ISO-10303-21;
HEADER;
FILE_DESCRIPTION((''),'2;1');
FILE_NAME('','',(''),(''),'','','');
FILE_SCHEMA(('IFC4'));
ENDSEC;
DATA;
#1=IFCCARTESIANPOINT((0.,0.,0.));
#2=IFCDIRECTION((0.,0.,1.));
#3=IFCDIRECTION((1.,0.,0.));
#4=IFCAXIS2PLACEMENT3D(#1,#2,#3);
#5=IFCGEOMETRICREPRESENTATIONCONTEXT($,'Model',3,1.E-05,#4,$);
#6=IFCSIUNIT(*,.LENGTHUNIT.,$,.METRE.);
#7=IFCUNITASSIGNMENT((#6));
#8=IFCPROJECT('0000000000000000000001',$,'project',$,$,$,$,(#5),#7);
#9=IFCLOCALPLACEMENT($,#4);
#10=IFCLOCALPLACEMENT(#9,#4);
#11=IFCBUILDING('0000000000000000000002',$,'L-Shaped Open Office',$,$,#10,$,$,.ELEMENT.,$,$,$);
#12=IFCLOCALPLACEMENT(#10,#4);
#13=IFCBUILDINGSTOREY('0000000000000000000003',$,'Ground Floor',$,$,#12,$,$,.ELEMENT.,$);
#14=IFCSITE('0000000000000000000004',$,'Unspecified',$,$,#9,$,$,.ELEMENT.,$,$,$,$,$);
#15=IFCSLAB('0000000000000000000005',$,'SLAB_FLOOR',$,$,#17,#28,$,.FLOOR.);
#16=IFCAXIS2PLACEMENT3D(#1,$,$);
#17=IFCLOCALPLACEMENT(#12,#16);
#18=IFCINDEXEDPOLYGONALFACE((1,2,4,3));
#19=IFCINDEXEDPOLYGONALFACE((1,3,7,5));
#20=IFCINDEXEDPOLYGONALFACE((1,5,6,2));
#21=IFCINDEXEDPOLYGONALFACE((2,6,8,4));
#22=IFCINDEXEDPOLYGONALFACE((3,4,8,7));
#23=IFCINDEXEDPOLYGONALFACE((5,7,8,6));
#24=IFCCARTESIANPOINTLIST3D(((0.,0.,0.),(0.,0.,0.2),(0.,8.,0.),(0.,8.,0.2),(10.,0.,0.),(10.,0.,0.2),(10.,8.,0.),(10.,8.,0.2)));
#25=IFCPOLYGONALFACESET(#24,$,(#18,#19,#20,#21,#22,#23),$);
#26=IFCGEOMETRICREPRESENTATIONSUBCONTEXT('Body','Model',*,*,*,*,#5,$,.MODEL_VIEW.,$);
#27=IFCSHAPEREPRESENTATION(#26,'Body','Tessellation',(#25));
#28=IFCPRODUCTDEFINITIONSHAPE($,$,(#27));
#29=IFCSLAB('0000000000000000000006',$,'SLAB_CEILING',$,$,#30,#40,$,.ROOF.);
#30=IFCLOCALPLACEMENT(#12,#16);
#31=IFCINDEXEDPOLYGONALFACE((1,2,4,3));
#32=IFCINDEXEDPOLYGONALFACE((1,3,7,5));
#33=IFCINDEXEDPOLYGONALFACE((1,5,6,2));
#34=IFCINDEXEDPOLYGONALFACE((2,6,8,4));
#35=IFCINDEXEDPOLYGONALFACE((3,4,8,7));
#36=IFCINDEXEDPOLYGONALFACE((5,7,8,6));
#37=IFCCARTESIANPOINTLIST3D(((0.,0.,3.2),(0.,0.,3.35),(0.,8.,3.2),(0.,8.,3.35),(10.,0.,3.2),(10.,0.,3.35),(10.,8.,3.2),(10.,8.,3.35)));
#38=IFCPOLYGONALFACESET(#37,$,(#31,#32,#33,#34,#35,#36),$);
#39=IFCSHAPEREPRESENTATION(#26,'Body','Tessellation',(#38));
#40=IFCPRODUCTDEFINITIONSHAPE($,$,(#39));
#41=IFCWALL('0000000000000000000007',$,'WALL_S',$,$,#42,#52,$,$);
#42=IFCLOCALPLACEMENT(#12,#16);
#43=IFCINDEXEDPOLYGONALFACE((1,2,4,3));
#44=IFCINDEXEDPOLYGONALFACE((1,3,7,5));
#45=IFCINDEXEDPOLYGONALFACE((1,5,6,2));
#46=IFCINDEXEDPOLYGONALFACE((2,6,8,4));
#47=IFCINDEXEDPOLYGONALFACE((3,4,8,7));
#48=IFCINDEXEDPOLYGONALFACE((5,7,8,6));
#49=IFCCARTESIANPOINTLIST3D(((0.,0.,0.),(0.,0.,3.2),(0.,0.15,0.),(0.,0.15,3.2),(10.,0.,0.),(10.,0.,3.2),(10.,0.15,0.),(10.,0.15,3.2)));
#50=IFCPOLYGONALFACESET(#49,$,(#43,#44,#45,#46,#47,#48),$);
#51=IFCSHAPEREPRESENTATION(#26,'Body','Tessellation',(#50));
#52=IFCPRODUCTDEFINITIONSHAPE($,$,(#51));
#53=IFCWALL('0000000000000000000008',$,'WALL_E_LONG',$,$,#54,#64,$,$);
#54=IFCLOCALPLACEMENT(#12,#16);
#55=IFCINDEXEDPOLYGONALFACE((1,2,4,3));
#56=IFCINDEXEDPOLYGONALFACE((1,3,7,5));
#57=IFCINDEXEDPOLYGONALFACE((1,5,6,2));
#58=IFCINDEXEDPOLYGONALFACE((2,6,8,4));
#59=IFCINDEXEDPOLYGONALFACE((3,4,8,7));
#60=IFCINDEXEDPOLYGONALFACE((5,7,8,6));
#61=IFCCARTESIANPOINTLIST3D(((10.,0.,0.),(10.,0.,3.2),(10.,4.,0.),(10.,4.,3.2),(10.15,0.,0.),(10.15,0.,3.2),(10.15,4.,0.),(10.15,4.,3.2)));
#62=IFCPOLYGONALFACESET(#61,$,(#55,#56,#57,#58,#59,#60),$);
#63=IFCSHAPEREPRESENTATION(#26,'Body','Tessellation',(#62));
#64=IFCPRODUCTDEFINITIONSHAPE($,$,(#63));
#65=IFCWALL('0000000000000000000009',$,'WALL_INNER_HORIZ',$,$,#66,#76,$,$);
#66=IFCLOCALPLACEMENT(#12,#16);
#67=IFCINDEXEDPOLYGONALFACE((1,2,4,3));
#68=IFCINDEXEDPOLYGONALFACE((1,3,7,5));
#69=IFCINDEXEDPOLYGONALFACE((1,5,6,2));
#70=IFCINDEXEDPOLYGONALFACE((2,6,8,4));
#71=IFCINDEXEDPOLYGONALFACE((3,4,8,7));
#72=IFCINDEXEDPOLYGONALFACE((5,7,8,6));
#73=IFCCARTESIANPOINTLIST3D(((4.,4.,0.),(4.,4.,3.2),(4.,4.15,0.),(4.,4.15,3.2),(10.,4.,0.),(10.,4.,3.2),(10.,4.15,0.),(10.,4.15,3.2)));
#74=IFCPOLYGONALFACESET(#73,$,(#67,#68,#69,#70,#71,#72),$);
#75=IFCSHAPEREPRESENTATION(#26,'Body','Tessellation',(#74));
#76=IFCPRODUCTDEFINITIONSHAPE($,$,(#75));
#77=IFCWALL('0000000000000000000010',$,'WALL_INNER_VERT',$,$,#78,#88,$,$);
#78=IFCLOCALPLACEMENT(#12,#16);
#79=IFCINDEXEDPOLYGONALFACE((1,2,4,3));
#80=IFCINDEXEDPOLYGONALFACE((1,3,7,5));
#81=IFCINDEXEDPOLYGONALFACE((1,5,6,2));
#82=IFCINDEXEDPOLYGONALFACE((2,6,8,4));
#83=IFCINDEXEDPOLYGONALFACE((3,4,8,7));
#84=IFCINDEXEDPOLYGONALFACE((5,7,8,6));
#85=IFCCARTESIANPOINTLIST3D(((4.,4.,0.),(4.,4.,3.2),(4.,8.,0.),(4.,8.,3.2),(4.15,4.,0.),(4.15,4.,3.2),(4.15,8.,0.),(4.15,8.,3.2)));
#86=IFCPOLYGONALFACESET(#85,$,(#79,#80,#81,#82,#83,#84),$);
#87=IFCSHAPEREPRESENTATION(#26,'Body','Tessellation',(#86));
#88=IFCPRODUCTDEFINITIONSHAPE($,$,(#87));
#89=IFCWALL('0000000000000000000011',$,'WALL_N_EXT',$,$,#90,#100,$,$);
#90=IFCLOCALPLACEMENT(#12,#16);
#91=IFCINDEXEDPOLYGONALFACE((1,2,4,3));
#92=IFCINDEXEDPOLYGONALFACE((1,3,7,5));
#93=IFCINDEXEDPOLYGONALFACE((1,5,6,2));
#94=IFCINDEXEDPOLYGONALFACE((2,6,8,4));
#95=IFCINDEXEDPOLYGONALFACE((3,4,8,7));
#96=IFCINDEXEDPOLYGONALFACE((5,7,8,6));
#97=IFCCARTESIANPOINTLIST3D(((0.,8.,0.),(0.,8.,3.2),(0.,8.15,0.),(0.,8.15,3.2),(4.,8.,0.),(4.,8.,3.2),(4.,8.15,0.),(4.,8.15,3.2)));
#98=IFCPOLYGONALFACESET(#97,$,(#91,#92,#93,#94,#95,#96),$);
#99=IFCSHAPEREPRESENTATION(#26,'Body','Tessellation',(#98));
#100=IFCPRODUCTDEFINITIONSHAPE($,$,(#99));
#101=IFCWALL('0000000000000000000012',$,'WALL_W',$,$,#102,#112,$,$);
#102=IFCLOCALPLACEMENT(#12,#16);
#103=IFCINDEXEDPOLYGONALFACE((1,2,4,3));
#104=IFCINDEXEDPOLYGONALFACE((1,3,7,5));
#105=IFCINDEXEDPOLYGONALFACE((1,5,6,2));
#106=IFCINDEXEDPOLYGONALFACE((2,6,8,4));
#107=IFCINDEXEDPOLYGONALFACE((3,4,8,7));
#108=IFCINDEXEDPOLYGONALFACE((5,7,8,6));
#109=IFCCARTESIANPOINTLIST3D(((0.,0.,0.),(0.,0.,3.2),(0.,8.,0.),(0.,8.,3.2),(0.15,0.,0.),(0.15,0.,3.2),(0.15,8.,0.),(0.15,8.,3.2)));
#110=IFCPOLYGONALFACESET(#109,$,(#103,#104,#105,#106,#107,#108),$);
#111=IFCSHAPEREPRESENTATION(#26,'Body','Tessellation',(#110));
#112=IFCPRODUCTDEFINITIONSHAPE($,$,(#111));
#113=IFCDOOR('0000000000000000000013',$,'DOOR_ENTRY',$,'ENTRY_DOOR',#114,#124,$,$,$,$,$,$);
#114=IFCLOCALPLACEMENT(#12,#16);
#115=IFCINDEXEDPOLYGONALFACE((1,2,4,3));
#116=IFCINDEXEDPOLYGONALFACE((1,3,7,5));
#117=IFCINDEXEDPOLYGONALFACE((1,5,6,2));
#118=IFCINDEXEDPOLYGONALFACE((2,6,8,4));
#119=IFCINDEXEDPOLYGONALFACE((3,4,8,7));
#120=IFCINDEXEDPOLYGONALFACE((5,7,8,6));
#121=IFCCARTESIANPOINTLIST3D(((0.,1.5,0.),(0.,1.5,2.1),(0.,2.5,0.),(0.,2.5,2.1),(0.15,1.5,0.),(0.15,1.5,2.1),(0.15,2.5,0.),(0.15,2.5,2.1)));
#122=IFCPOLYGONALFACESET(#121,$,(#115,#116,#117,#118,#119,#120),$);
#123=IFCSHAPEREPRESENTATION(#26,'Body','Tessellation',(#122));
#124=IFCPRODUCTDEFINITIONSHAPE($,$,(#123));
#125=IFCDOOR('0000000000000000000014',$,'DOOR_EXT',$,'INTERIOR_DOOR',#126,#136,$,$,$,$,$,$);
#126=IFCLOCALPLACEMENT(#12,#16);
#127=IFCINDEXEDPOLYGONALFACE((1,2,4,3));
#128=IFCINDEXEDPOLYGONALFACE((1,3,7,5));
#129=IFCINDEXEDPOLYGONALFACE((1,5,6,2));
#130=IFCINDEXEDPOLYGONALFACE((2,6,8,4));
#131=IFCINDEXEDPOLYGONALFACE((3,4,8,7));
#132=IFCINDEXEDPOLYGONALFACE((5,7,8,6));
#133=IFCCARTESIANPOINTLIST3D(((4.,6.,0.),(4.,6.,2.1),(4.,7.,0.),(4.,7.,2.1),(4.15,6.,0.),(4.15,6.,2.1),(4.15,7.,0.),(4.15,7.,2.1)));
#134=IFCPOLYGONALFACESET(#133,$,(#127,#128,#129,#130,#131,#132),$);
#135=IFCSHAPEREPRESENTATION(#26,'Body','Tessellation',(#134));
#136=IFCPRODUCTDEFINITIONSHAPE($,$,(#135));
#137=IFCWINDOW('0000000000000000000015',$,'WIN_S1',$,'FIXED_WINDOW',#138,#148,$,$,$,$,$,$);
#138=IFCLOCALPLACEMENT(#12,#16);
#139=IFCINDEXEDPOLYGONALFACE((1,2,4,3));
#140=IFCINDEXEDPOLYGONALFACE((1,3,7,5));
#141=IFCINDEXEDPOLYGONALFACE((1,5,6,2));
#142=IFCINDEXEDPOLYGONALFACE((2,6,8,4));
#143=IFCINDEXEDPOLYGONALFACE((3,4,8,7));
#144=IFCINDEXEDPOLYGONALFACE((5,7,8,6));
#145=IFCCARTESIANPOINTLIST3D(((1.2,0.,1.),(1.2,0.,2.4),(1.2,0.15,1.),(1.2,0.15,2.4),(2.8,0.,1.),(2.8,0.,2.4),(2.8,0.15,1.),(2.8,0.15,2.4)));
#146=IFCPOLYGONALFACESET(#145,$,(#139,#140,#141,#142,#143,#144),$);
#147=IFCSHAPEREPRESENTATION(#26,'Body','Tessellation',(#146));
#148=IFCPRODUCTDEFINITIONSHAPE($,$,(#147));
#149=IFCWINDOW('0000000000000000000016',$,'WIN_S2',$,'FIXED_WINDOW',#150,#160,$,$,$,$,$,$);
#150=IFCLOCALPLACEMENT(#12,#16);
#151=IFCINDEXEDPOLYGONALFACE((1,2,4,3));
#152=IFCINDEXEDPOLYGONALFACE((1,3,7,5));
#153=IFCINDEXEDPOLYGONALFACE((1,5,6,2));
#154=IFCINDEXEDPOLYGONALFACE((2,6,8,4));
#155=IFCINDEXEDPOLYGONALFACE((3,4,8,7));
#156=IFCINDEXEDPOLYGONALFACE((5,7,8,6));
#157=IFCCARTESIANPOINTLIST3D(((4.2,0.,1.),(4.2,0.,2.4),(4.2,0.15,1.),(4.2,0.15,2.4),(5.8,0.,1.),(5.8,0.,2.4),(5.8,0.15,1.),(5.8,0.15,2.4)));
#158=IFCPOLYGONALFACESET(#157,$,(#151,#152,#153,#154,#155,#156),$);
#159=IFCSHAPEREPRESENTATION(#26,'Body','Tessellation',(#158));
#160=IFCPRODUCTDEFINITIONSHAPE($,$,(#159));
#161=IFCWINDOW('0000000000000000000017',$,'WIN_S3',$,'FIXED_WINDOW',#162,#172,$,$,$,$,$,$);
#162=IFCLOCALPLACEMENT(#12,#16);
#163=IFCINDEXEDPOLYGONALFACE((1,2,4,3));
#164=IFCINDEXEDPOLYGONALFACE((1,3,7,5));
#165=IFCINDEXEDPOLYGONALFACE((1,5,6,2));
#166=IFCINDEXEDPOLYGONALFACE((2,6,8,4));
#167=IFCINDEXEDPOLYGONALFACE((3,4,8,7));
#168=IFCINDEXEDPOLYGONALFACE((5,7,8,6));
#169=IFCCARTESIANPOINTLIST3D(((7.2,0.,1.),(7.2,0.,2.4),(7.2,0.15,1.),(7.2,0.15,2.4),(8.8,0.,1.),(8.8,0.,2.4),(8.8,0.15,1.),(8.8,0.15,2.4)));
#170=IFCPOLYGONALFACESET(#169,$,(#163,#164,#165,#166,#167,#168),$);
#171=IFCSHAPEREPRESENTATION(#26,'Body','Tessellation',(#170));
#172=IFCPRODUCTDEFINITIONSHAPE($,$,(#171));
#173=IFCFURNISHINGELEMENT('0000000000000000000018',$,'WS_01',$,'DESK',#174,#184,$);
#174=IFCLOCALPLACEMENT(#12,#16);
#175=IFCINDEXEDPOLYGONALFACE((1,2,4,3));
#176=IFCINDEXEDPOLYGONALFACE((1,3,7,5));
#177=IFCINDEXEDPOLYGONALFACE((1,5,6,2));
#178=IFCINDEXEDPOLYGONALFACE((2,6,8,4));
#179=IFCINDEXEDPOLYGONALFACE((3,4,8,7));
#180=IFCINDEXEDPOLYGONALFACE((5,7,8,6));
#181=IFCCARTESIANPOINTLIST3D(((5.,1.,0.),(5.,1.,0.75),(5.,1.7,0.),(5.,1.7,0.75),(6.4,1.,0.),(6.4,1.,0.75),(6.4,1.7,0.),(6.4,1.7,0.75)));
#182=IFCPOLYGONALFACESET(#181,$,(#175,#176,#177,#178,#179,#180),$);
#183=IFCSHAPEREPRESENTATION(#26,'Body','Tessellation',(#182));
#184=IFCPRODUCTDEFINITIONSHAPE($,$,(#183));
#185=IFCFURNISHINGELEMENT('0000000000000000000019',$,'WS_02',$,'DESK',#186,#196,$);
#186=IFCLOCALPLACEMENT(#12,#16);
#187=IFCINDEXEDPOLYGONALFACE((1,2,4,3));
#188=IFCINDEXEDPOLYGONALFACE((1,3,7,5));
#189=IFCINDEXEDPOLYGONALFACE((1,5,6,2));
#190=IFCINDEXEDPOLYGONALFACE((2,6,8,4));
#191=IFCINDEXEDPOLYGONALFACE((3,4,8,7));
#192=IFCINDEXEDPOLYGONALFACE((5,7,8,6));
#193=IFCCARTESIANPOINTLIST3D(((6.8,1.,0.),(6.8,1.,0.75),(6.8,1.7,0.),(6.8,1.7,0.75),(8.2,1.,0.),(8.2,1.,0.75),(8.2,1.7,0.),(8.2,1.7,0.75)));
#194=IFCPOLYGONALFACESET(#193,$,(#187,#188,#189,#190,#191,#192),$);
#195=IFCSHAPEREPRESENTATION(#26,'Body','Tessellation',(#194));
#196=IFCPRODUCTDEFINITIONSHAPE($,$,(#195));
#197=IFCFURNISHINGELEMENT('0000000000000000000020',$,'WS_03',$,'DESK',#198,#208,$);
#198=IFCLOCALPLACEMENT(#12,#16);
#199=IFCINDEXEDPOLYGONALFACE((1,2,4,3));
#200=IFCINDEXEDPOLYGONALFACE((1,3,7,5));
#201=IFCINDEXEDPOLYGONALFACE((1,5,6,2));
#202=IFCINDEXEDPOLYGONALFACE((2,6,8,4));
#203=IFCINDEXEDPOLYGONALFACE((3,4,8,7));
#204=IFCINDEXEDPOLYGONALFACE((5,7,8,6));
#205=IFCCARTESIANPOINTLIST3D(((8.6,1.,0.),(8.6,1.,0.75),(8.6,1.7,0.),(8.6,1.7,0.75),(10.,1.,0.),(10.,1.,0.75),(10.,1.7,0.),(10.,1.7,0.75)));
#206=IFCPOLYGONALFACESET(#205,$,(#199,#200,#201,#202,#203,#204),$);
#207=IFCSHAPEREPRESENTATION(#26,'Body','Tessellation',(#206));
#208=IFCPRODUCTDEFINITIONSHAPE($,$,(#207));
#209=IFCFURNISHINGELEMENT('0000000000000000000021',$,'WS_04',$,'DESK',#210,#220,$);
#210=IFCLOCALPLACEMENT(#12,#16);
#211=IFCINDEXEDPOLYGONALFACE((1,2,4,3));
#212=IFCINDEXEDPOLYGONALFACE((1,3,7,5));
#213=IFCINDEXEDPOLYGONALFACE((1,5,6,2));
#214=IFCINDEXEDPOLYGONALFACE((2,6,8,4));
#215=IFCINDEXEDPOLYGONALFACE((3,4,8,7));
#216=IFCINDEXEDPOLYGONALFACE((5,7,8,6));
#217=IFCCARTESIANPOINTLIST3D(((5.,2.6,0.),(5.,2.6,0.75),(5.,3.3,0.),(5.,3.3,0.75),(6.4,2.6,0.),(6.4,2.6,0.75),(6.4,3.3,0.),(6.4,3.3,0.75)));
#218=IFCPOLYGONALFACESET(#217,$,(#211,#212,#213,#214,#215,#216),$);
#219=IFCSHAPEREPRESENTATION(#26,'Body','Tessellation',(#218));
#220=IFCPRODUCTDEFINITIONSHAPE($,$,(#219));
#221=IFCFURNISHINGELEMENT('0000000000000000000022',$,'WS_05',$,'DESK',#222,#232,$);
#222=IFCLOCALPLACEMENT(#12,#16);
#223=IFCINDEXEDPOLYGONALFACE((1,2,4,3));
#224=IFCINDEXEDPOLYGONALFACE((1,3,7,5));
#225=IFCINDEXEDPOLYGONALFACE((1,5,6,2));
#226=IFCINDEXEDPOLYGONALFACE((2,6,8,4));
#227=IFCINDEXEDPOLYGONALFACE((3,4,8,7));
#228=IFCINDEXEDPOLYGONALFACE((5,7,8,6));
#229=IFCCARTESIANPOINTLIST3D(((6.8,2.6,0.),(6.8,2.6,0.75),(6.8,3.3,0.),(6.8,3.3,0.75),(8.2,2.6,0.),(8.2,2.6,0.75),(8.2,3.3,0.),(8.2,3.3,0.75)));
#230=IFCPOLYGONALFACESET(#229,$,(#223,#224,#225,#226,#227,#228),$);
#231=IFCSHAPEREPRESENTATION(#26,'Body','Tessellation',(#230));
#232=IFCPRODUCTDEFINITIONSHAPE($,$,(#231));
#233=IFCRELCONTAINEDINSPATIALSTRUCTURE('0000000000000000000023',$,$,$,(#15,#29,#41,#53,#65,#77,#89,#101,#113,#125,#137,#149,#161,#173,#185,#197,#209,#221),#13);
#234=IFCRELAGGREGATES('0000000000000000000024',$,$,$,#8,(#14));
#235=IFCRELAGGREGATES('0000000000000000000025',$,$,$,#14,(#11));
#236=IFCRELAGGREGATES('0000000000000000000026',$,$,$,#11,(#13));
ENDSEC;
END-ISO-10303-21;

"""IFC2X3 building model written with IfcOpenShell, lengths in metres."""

from ifc_helpers import new_model, si_unit, frame, frame_2d, origin, origin_with_axes, place, context, subcontext, project, spatial, rectangle, extrude, element, save


model = new_model("IFC2X3")

# Units and contexts
model_context = context("Model", 3, precision=1e-05, world=origin_with_axes())
body_context = subcontext(model_context, "Body", "Model", "MODEL_VIEW")
ifc_project = project(units=[si_unit("LENGTHUNIT", "METRE")], contexts=[model_context])

# Site, building, storey
site_placement = place(None, origin_with_axes())
site = spatial("IfcSite", under=ifc_project, at=site_placement, Name="Unspecified", CompositionType="ELEMENT")
building_placement = place(site_placement, origin_with_axes())
building = spatial("IfcBuilding", under=site, at=building_placement, Name="L-Shaped Open Office", CompositionType="ELEMENT")
storey_placement = place(building_placement, origin_with_axes())
storey = spatial("IfcBuildingStorey", under=building, at=storey_placement, Name="Ground Floor", CompositionType="ELEMENT")

# Slabs
slab_1_placement = place(storey_placement, origin_with_axes())
element("IfcSlab", 1, at=slab_1_placement, inside=storey, Name="SLAB_FLOOR", PredefinedType="FLOOR", context=body_context, shape_type="SweptSolid", body=[
    extrude(rectangle(XDim=10.0, YDim=8.0, at=frame_2d((5.0, 4.0))), origin(), (0.0, 0.0, 1.0), 0.2),
])
slab_2_placement = place(storey_placement, frame((0.0, 0.0, 3.2), z_axis=(0.0, 0.0, 1.0), x_axis=(1.0, 0.0, 0.0)))
element("IfcSlab", 2, at=slab_2_placement, inside=storey, Name="SLAB_CEILING", PredefinedType="ROOF", context=body_context, shape_type="SweptSolid", body=[
    extrude(rectangle(XDim=10.0, YDim=8.0, at=frame_2d((5.0, 4.0))), origin(), (0.0, 0.0, 1.0), 0.15),
])

# Walls
wall_1_placement = place(storey_placement, origin_with_axes())
element("IfcWall", 3, at=wall_1_placement, inside=storey, Name="WALL_S", context=body_context, shape_type="SweptSolid", body=[
    extrude(rectangle(XDim=10.0, YDim=0.15, at=frame_2d((5.0, 0.075))), origin(), (0.0, 0.0, 1.0), 3.2),
])
wall_2_placement = place(storey_placement, frame((10.0, 0.0, 0.0), z_axis=(0.0, 0.0, 1.0), x_axis=(1.0, 0.0, 0.0)))
element("IfcWall", 4, at=wall_2_placement, inside=storey, Name="WALL_E_LONG", context=body_context, shape_type="SweptSolid", body=[
    extrude(rectangle(XDim=0.15, YDim=4.0, at=frame_2d((0.075, 2.0))), origin(), (0.0, 0.0, 1.0), 3.2),
])
wall_3_placement = place(storey_placement, frame((4.0, 4.0, 0.0), z_axis=(0.0, 0.0, 1.0), x_axis=(1.0, 0.0, 0.0)))
element("IfcWall", 5, at=wall_3_placement, inside=storey, Name="WALL_INNER_HORIZ", context=body_context, shape_type="SweptSolid", body=[
    extrude(rectangle(XDim=6.0, YDim=0.15, at=frame_2d((3.0, 0.075))), origin(), (0.0, 0.0, 1.0), 3.2),
])
wall_4_placement = place(storey_placement, frame((4.0, 4.0, 0.0), z_axis=(0.0, 0.0, 1.0), x_axis=(1.0, 0.0, 0.0)))
element("IfcWall", 6, at=wall_4_placement, inside=storey, Name="WALL_INNER_VERT", context=body_context, shape_type="SweptSolid", body=[
    extrude(rectangle(XDim=0.15, YDim=4.0, at=frame_2d((0.075, 2.0))), origin(), (0.0, 0.0, 1.0), 3.2),
])
wall_5_placement = place(storey_placement, frame((0.0, 8.0, 0.0), z_axis=(0.0, 0.0, 1.0), x_axis=(1.0, 0.0, 0.0)))
element("IfcWall", 7, at=wall_5_placement, inside=storey, Name="WALL_N_EXT", context=body_context, shape_type="SweptSolid", body=[
    extrude(rectangle(XDim=4.0, YDim=0.15, at=frame_2d((2.0, 0.075))), origin(), (0.0, 0.0, 1.0), 3.2),
])
wall_6_placement = place(storey_placement, origin_with_axes())
element("IfcWall", 8, at=wall_6_placement, inside=storey, Name="WALL_W", context=body_context, shape_type="SweptSolid", body=[
    extrude(rectangle(XDim=0.15, YDim=8.0, at=frame_2d((0.075, 4.0))), origin(), (0.0, 0.0, 1.0), 3.2),
])

# Doors
door_1_placement = place(storey_placement, frame((0.0, 1.5, 0.0), z_axis=(0.0, 0.0, 1.0), x_axis=(1.0, 0.0, 0.0)))
element("IfcDoor", 9, at=door_1_placement, inside=storey, Name="DOOR_ENTRY", ObjectType="ENTRY_DOOR", context=body_context, shape_type="SweptSolid", body=[
    extrude(rectangle(XDim=0.15, YDim=1.0, at=frame_2d((0.075, 0.5))), origin(), (0.0, 0.0, 1.0), 2.1),
])
door_2_placement = place(storey_placement, frame((4.0, 6.0, 0.0), z_axis=(0.0, 0.0, 1.0), x_axis=(1.0, 0.0, 0.0)))
element("IfcDoor", 10, at=door_2_placement, inside=storey, Name="DOOR_EXT", ObjectType="INTERIOR_DOOR", context=body_context, shape_type="SweptSolid", body=[
    extrude(rectangle(XDim=0.15, YDim=1.0, at=frame_2d((0.075, 0.5))), origin(), (0.0, 0.0, 1.0), 2.1),
])

# Windows
for number, where, z_axis, x_axis, name in (
    (11, (1.2, 0.0, 1.0), (0.0, 0.0, 1.0), (1.0, 0.0, 0.0), "WIN_S1"),
    (12, (4.2, 0.0, 1.0), (0.0, 0.0, 1.0), (1.0, 0.0, 0.0), "WIN_S2"),
    (13, (7.2, 0.0, 1.0), (0.0, 0.0, 1.0), (1.0, 0.0, 0.0), "WIN_S3"),
):
    element("IfcWindow", number, at=place(storey_placement, frame(where, z_axis=z_axis, x_axis=x_axis)), inside=storey, Name=name, ObjectType="FIXED_WINDOW", context=body_context, shape_type="SweptSolid", body=[
        extrude(rectangle(XDim=1.6, YDim=0.15, at=frame_2d((0.8, 0.075))), origin(), (0.0, 0.0, 1.0), 1.4),
    ])

# Furnishing elements
for number, where, z_axis, x_axis, name in (
    (14, (5.0, 1.0, 0.0), (0.0, 0.0, 1.0), (1.0, 0.0, 0.0), "WS_01"),
    (15, (6.8, 1.0, 0.0), (0.0, 0.0, 1.0), (1.0, 0.0, 0.0), "WS_02"),
    (16, (8.6, 1.0, 0.0), (0.0, 0.0, 1.0), (1.0, 0.0, 0.0), "WS_03"),
    (17, (5.0, 2.6, 0.0), (0.0, 0.0, 1.0), (1.0, 0.0, 0.0), "WS_04"),
    (18, (6.8, 2.6, 0.0), (0.0, 0.0, 1.0), (1.0, 0.0, 0.0), "WS_05"),
):
    element("IfcFurnishingElement", number, at=place(storey_placement, frame(where, z_axis=z_axis, x_axis=x_axis)), inside=storey, Name=name, ObjectType="DESK", context=body_context, shape_type="SweptSolid", body=[
        extrude(rectangle(XDim=1.4, YDim=0.7, at=frame_2d((0.7, 0.35))), origin(), (0.0, 0.0, 1.0), 0.75),
    ])

save(model, "model.ifc")
